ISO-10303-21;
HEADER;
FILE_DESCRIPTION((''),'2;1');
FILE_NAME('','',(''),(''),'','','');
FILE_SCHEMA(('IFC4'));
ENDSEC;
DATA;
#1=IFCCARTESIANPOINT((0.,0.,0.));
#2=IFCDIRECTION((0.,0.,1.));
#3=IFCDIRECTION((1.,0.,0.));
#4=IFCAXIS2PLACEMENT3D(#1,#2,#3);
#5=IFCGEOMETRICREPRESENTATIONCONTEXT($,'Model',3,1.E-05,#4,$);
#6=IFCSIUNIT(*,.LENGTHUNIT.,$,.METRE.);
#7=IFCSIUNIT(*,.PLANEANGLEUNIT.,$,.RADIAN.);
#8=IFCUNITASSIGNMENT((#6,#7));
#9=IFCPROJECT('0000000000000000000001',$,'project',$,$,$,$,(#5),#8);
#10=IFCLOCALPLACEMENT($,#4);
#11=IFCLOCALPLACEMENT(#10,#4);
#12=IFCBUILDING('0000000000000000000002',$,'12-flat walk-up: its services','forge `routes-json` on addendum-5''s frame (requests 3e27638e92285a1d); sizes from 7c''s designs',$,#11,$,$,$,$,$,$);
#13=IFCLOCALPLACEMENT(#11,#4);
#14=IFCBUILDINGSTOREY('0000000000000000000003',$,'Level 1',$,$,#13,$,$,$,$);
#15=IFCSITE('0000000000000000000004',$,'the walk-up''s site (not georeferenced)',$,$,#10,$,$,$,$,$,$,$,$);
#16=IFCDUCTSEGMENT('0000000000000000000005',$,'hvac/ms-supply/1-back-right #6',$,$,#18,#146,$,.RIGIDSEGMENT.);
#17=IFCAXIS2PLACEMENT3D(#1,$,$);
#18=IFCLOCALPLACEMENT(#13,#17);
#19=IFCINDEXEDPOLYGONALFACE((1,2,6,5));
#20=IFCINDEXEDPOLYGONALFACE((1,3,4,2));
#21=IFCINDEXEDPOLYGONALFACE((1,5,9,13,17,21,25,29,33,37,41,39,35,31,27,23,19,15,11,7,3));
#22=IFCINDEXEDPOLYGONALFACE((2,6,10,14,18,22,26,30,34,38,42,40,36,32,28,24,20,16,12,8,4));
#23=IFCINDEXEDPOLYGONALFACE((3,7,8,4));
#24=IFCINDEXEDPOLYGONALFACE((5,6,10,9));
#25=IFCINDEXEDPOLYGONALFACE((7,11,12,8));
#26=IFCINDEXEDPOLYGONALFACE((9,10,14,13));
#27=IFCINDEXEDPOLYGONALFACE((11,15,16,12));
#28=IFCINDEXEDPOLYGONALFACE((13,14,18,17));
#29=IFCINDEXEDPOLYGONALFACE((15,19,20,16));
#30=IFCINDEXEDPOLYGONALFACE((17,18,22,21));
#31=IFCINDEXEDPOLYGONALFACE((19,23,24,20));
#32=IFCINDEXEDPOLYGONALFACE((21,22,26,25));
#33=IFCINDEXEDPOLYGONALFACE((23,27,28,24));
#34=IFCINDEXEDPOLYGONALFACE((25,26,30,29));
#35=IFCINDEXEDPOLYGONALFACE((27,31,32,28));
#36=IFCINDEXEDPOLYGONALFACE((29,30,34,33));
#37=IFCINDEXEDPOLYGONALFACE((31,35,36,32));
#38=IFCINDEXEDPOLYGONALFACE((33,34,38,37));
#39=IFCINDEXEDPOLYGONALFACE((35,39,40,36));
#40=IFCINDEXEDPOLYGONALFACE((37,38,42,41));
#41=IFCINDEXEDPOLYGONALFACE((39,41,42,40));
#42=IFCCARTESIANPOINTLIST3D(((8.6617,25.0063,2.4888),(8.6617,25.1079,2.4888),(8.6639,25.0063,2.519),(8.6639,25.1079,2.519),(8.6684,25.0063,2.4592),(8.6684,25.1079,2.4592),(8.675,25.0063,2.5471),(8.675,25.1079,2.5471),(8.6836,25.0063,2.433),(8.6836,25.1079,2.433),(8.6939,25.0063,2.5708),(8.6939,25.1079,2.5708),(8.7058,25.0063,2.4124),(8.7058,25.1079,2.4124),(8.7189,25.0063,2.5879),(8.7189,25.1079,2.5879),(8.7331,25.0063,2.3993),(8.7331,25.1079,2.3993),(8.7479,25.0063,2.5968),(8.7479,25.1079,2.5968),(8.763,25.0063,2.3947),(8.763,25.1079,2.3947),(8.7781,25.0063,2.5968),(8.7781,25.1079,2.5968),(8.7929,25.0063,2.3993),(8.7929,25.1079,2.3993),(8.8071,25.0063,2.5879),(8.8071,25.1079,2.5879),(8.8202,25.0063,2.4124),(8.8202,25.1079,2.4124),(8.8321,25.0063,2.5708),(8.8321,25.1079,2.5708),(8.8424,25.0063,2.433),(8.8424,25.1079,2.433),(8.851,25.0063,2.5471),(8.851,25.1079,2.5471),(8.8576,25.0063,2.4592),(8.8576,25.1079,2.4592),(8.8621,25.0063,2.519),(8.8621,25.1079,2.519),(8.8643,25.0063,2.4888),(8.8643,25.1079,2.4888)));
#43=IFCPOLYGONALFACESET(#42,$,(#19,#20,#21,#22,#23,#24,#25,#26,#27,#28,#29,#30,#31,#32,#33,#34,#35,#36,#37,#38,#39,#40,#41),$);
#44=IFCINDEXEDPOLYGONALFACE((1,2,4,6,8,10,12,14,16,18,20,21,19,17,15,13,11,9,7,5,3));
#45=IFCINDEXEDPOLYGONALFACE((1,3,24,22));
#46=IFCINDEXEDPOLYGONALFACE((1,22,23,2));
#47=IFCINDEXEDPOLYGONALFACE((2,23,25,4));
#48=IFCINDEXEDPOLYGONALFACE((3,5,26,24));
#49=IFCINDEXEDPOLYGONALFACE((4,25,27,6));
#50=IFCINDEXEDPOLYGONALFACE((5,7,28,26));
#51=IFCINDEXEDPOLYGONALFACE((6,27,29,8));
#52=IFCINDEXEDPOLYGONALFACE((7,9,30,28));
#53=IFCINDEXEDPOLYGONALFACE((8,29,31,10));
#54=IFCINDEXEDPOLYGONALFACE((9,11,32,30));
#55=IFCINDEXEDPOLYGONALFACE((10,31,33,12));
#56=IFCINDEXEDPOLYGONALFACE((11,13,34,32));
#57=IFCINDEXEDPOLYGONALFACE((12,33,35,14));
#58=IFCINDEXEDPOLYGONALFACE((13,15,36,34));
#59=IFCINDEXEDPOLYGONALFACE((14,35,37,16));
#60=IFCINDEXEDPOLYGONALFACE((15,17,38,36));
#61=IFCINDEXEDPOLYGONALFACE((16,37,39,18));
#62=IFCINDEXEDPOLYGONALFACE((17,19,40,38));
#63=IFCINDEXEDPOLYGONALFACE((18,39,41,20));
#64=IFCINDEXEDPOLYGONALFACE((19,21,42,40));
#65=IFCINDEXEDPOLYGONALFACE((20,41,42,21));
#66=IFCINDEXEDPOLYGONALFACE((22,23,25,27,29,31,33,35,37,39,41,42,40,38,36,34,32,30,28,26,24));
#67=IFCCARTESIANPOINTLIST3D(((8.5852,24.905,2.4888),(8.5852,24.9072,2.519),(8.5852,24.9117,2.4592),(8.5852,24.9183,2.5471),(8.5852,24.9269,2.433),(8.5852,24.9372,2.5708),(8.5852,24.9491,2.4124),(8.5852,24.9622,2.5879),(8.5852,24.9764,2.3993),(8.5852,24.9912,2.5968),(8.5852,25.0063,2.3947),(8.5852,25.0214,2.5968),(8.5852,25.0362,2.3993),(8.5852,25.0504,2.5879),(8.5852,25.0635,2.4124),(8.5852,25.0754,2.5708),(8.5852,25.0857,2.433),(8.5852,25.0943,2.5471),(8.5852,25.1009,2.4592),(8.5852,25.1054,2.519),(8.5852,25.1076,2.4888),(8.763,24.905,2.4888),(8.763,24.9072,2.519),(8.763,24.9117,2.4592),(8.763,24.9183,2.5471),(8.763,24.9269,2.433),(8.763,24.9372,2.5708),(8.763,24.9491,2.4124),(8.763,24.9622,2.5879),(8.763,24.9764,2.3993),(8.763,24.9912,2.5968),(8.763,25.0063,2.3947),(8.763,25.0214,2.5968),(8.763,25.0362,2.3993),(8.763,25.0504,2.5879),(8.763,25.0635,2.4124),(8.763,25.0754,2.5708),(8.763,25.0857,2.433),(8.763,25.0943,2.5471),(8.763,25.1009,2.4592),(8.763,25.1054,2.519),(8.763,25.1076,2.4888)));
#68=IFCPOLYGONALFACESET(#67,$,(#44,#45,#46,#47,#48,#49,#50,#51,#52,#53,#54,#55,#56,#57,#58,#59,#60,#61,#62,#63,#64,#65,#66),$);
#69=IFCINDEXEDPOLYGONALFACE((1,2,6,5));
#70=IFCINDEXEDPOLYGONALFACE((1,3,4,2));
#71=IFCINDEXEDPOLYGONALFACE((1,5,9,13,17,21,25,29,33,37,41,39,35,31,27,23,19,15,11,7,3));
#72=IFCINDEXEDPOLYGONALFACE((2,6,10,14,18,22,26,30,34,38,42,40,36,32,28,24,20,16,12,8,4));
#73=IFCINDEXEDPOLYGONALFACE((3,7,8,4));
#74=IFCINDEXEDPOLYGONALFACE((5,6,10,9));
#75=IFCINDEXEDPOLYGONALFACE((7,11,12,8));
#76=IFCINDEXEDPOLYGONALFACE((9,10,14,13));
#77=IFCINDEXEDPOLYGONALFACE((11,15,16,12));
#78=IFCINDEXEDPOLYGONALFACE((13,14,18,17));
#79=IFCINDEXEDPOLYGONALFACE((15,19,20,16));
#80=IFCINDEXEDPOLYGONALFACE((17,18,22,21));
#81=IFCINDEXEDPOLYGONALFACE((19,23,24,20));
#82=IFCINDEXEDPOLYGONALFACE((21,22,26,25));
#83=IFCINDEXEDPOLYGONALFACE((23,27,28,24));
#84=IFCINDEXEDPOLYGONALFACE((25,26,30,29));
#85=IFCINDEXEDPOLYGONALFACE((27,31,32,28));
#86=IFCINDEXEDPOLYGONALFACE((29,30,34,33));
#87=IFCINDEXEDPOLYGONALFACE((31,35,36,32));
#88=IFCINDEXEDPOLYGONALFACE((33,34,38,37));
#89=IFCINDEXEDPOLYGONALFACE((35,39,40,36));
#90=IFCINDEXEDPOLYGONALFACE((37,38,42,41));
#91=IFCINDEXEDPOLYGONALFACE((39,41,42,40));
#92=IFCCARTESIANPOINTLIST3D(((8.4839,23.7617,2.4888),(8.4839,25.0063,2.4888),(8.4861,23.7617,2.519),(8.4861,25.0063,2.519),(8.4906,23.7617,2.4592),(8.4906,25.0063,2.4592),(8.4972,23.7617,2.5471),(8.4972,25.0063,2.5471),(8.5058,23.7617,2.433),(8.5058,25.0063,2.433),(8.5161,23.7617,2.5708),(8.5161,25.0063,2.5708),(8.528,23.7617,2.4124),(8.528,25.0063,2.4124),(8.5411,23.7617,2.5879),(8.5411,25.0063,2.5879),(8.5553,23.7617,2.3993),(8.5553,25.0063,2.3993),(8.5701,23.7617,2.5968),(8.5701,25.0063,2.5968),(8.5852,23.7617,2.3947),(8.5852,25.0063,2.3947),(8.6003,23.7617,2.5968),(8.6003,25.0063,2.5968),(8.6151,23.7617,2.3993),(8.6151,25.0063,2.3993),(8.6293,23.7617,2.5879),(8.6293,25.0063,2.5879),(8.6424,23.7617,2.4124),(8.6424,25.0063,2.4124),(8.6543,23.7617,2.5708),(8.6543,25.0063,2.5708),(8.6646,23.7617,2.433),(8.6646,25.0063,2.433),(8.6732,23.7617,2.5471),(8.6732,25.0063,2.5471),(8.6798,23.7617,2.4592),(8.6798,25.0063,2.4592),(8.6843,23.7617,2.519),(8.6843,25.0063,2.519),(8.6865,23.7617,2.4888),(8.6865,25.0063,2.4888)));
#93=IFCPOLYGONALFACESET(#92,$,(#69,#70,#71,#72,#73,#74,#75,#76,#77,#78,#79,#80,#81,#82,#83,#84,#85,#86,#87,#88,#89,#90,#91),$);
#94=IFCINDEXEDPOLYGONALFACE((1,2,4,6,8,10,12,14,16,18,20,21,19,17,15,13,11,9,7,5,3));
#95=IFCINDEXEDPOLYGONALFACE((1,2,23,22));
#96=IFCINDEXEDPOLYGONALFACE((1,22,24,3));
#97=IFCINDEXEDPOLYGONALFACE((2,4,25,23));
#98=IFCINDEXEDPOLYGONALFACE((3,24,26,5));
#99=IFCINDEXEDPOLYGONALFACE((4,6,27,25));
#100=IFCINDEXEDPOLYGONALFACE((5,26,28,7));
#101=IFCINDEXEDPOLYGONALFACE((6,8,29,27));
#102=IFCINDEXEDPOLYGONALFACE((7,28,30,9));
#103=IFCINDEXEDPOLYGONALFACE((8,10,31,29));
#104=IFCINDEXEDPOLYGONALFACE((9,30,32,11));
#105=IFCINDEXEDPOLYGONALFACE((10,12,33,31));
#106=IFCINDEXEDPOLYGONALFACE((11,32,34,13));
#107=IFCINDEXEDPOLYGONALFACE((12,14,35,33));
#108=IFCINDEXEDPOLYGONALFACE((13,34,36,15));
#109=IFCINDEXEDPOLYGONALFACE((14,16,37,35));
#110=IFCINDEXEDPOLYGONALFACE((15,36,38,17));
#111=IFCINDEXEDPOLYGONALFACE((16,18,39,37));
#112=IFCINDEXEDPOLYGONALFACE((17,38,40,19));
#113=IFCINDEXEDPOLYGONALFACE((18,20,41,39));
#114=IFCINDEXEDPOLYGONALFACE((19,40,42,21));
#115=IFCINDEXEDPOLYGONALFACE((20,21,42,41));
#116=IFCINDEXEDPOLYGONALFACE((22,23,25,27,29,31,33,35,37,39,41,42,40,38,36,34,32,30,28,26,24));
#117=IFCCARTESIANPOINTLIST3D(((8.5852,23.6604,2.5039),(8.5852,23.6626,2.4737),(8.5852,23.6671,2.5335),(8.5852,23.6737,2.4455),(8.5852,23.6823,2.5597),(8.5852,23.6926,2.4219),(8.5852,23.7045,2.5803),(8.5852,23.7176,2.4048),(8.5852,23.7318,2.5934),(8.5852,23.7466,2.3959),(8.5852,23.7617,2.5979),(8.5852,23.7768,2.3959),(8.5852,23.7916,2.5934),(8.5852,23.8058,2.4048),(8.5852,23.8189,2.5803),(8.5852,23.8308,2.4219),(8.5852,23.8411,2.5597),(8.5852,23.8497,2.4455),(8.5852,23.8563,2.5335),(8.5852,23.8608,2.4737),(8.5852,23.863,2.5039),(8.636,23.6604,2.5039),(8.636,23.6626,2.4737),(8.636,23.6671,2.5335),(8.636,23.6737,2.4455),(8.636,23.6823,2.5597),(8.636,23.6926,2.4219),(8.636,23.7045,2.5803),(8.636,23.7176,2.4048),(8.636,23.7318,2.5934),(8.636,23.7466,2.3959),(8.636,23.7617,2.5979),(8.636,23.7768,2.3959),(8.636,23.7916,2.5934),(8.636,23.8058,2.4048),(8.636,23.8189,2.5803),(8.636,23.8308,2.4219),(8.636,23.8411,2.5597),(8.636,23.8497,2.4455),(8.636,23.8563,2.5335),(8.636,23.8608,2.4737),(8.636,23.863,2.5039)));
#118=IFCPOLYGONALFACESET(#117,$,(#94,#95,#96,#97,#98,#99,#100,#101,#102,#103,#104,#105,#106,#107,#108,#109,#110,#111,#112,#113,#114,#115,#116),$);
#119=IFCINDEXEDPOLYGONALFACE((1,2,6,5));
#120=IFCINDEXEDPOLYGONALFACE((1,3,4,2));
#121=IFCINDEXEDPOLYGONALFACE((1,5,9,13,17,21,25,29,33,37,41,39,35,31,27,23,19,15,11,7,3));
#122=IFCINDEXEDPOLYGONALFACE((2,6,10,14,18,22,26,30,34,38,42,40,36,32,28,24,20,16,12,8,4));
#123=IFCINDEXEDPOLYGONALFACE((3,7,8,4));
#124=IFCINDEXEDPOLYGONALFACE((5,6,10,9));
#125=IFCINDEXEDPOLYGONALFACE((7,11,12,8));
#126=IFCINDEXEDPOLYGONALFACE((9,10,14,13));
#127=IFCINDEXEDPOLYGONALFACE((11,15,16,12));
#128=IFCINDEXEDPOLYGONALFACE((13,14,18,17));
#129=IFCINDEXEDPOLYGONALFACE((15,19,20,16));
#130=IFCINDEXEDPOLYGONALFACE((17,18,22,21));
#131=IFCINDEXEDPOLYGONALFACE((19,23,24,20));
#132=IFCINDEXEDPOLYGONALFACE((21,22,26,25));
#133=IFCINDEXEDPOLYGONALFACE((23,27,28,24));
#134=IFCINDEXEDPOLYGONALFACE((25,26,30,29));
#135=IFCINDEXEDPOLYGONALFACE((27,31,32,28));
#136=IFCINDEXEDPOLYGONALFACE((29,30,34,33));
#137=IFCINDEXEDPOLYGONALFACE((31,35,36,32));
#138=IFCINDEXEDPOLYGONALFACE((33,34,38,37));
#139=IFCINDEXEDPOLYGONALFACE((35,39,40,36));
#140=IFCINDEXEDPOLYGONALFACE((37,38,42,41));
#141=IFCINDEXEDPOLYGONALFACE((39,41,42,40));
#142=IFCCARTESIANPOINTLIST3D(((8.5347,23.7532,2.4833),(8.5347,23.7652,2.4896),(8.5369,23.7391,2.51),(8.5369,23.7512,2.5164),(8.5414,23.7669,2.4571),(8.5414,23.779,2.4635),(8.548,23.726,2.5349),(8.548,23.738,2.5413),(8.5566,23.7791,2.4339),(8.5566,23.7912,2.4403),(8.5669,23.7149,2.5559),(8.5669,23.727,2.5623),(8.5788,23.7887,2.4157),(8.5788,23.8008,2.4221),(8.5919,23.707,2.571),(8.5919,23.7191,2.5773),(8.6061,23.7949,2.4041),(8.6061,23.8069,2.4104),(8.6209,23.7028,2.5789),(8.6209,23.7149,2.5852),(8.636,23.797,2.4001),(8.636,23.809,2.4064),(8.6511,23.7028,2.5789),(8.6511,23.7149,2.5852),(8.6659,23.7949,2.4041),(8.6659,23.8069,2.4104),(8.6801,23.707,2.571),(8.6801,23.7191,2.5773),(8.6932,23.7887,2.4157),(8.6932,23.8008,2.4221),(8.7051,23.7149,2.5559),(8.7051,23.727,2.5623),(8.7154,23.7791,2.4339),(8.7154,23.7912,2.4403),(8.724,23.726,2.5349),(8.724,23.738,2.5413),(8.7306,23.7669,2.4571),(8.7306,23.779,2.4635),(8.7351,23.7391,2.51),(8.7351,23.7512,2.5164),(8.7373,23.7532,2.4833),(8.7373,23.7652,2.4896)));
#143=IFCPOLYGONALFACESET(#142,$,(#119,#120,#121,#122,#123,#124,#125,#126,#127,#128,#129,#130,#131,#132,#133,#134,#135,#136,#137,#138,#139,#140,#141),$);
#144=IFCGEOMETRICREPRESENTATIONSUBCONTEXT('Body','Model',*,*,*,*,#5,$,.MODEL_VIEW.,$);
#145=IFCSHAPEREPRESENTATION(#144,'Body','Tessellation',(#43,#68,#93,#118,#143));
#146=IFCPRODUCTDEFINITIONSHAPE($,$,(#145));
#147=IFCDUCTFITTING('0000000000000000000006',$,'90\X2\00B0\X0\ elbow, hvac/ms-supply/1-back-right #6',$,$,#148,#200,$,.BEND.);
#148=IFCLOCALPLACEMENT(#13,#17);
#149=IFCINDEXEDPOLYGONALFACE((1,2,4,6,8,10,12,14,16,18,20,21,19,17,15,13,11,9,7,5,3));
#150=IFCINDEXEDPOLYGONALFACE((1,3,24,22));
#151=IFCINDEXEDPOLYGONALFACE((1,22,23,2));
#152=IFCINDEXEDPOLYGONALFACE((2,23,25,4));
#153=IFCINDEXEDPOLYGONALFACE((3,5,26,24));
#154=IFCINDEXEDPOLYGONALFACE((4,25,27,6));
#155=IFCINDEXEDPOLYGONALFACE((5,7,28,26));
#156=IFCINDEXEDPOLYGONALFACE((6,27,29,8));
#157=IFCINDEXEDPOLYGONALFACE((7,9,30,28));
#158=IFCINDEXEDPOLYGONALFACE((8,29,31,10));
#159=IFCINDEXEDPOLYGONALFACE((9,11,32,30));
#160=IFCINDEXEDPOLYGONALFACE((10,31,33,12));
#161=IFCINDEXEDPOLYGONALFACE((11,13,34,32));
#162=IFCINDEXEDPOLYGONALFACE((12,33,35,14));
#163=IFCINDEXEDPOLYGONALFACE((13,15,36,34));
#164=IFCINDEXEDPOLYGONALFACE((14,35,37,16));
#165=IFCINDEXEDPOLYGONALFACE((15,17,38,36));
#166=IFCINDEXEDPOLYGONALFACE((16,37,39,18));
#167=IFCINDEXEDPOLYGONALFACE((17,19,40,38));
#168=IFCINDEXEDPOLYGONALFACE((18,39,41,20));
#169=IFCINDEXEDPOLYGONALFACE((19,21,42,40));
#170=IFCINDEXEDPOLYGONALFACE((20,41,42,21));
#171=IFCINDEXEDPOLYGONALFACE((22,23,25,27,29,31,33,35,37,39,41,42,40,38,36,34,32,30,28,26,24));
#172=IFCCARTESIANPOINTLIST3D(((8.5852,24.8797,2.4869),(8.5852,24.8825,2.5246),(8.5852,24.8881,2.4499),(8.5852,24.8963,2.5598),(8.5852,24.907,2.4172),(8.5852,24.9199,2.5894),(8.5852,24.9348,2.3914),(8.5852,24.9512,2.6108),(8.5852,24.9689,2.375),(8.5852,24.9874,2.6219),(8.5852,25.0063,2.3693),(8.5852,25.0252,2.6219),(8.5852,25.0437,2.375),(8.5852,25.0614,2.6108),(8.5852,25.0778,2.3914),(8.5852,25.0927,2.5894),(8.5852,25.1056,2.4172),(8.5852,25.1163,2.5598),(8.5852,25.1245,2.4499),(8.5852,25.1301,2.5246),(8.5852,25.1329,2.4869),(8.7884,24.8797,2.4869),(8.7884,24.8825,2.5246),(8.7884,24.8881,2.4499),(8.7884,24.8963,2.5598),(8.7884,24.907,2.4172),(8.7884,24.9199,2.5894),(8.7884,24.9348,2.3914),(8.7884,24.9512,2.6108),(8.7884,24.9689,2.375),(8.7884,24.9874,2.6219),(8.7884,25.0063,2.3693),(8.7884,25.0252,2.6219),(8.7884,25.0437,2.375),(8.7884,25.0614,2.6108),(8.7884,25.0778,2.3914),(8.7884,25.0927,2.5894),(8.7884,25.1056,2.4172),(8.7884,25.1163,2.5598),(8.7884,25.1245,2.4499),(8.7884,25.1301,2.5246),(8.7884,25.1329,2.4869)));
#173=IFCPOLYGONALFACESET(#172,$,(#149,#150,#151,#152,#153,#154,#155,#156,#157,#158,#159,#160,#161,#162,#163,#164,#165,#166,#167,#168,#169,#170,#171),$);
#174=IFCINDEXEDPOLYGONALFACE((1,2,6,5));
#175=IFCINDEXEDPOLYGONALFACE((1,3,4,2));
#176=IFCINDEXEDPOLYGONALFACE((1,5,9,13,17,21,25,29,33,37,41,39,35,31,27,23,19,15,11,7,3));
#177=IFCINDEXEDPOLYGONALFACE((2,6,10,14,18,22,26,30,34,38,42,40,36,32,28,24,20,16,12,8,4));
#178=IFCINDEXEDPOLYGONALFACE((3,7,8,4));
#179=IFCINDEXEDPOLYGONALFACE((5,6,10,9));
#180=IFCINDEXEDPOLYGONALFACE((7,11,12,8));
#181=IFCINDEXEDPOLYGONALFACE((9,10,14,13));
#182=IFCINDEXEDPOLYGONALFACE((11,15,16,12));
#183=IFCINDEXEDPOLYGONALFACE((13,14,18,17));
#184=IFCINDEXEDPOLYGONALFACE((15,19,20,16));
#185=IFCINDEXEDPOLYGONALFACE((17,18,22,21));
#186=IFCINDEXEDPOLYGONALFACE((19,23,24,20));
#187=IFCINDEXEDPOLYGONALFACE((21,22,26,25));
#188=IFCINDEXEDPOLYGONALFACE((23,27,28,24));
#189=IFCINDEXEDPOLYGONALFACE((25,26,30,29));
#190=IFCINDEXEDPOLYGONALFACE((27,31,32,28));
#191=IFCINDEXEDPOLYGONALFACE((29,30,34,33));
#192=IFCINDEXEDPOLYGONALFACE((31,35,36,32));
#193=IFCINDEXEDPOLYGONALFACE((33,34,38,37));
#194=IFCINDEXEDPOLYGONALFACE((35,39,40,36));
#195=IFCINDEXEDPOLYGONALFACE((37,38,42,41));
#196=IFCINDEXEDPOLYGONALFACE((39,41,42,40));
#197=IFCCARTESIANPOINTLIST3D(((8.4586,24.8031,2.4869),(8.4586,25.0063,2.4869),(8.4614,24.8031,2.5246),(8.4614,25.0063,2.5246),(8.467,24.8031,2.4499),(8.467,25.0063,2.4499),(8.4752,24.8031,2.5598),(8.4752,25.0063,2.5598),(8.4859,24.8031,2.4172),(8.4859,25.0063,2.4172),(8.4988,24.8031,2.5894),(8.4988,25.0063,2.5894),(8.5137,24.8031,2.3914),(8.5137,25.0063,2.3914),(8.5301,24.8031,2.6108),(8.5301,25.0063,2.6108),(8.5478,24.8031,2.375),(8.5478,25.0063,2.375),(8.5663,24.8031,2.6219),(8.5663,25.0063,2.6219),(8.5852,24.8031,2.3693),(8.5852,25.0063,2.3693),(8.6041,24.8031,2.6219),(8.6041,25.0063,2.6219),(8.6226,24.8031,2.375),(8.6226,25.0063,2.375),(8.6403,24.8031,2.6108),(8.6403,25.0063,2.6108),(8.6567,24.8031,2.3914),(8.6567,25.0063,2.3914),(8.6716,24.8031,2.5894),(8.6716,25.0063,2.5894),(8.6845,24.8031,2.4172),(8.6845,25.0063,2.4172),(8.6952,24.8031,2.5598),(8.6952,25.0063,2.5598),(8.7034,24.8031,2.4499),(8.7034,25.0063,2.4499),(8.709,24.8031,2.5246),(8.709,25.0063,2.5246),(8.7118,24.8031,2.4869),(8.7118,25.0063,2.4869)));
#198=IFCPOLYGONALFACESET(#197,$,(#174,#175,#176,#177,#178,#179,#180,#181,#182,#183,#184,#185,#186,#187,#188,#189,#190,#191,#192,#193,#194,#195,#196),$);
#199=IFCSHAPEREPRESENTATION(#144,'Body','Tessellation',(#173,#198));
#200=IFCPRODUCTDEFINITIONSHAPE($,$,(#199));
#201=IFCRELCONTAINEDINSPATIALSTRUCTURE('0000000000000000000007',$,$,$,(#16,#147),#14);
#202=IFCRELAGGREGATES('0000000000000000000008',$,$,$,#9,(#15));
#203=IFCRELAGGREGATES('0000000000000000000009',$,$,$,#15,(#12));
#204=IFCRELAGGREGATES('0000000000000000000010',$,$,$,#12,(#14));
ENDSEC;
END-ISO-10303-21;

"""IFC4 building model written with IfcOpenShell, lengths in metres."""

from ifc_helpers import new_model, entity, si_unit, frame, origin_with_axes, place, context, subcontext, project, spatial, element, save


model = new_model("IFC4")

# Units and contexts
model_context = context("Model", 3, precision=1e-05, world=origin_with_axes())
body_context = subcontext(model_context, "Body", "Model", "MODEL_VIEW")
ifc_project = project(units=[si_unit("LENGTHUNIT", "METRE"), si_unit("PLANEANGLEUNIT", "RADIAN")], contexts=[model_context])

# Site, building, storey
site_placement = place(None, origin_with_axes())
site = spatial("IfcSite", under=ifc_project, at=site_placement, Name="the walk-up's site (not georeferenced)")
building_placement = place(site_placement, origin_with_axes())
building = spatial("IfcBuilding", under=site, at=building_placement, Name="12-flat walk-up: its services", Description="forge `routes-json` on addendum-5's frame (requests 3e27638e92285a1d); sizes from 7c's designs")
storey_placement = place(building_placement, origin_with_axes())
storey = spatial("IfcBuildingStorey", under=building, at=storey_placement, Name="Level 1")

# Duct segment
duct_segment_1_placement = place(storey_placement, frame((8.763, 25.1079, 2.4963), z_axis=(0.0, 0.0, 1.0), x_axis=(1.0, 0.0, 0.0)))
element("IfcDuctSegment", 1, at=duct_segment_1_placement, inside=storey, Name="hvac/ms-supply/1-back-right #6", PredefinedType="RIGIDSEGMENT", context=body_context, shape_type="AdvancedSweptSolid", body=[
    entity("IfcSweptDiskSolid", entity("IfcPolyline", [entity("IfcCartesianPoint", [0.0, 0.0, 0.0]), entity("IfcCartesianPoint", [0.0, -0.1016, 0.0])]), 0.1016),
    entity("IfcSweptDiskSolid", entity("IfcPolyline", [entity("IfcCartesianPoint", [0.0, -0.1016, 0.0]), entity("IfcCartesianPoint", [-0.1778, -0.1016, 0.0])]), 0.1016),
    entity("IfcSweptDiskSolid", entity("IfcPolyline", [entity("IfcCartesianPoint", [-0.1778, -0.1016, 0.0]), entity("IfcCartesianPoint", [-0.1778, -1.3462, 0.0])]), 0.1016),
    entity("IfcSweptDiskSolid", entity("IfcPolyline", [entity("IfcCartesianPoint", [-0.1778, -1.3462, 0.0]), entity("IfcCartesianPoint", [-0.127, -1.3462, 0.0])]), 0.1016),
    entity("IfcSweptDiskSolid", entity("IfcPolyline", [entity("IfcCartesianPoint", [-0.127, -1.3462, 0.0]), entity("IfcCartesianPoint", [-0.127, -1.3583, -0.0063])]), 0.1016),
])

# Duct fitting
duct_fitting_1_placement = place(storey_placement, frame((8.7884, 25.0063, 2.4963), z_axis=(0.0, 0.0, 1.0), x_axis=(1.0, 0.0, 0.0)))
element("IfcDuctFitting", 2, at=duct_fitting_1_placement, inside=storey, Name="90° elbow, hvac/ms-supply/1-back-right #6", PredefinedType="BEND", context=body_context, shape_type="AdvancedSweptSolid", body=[
    entity("IfcSweptDiskSolid", entity("IfcPolyline", [entity("IfcCartesianPoint", [0.0, 0.0, 0.0]), entity("IfcCartesianPoint", [-0.2032, 0.0, 0.0])]), 0.127),
    entity("IfcSweptDiskSolid", entity("IfcPolyline", [entity("IfcCartesianPoint", [-0.2032, 0.0, 0.0]), entity("IfcCartesianPoint", [-0.2032, -0.2032, 0.0])]), 0.127),
])

save(model, "model.ifc")
